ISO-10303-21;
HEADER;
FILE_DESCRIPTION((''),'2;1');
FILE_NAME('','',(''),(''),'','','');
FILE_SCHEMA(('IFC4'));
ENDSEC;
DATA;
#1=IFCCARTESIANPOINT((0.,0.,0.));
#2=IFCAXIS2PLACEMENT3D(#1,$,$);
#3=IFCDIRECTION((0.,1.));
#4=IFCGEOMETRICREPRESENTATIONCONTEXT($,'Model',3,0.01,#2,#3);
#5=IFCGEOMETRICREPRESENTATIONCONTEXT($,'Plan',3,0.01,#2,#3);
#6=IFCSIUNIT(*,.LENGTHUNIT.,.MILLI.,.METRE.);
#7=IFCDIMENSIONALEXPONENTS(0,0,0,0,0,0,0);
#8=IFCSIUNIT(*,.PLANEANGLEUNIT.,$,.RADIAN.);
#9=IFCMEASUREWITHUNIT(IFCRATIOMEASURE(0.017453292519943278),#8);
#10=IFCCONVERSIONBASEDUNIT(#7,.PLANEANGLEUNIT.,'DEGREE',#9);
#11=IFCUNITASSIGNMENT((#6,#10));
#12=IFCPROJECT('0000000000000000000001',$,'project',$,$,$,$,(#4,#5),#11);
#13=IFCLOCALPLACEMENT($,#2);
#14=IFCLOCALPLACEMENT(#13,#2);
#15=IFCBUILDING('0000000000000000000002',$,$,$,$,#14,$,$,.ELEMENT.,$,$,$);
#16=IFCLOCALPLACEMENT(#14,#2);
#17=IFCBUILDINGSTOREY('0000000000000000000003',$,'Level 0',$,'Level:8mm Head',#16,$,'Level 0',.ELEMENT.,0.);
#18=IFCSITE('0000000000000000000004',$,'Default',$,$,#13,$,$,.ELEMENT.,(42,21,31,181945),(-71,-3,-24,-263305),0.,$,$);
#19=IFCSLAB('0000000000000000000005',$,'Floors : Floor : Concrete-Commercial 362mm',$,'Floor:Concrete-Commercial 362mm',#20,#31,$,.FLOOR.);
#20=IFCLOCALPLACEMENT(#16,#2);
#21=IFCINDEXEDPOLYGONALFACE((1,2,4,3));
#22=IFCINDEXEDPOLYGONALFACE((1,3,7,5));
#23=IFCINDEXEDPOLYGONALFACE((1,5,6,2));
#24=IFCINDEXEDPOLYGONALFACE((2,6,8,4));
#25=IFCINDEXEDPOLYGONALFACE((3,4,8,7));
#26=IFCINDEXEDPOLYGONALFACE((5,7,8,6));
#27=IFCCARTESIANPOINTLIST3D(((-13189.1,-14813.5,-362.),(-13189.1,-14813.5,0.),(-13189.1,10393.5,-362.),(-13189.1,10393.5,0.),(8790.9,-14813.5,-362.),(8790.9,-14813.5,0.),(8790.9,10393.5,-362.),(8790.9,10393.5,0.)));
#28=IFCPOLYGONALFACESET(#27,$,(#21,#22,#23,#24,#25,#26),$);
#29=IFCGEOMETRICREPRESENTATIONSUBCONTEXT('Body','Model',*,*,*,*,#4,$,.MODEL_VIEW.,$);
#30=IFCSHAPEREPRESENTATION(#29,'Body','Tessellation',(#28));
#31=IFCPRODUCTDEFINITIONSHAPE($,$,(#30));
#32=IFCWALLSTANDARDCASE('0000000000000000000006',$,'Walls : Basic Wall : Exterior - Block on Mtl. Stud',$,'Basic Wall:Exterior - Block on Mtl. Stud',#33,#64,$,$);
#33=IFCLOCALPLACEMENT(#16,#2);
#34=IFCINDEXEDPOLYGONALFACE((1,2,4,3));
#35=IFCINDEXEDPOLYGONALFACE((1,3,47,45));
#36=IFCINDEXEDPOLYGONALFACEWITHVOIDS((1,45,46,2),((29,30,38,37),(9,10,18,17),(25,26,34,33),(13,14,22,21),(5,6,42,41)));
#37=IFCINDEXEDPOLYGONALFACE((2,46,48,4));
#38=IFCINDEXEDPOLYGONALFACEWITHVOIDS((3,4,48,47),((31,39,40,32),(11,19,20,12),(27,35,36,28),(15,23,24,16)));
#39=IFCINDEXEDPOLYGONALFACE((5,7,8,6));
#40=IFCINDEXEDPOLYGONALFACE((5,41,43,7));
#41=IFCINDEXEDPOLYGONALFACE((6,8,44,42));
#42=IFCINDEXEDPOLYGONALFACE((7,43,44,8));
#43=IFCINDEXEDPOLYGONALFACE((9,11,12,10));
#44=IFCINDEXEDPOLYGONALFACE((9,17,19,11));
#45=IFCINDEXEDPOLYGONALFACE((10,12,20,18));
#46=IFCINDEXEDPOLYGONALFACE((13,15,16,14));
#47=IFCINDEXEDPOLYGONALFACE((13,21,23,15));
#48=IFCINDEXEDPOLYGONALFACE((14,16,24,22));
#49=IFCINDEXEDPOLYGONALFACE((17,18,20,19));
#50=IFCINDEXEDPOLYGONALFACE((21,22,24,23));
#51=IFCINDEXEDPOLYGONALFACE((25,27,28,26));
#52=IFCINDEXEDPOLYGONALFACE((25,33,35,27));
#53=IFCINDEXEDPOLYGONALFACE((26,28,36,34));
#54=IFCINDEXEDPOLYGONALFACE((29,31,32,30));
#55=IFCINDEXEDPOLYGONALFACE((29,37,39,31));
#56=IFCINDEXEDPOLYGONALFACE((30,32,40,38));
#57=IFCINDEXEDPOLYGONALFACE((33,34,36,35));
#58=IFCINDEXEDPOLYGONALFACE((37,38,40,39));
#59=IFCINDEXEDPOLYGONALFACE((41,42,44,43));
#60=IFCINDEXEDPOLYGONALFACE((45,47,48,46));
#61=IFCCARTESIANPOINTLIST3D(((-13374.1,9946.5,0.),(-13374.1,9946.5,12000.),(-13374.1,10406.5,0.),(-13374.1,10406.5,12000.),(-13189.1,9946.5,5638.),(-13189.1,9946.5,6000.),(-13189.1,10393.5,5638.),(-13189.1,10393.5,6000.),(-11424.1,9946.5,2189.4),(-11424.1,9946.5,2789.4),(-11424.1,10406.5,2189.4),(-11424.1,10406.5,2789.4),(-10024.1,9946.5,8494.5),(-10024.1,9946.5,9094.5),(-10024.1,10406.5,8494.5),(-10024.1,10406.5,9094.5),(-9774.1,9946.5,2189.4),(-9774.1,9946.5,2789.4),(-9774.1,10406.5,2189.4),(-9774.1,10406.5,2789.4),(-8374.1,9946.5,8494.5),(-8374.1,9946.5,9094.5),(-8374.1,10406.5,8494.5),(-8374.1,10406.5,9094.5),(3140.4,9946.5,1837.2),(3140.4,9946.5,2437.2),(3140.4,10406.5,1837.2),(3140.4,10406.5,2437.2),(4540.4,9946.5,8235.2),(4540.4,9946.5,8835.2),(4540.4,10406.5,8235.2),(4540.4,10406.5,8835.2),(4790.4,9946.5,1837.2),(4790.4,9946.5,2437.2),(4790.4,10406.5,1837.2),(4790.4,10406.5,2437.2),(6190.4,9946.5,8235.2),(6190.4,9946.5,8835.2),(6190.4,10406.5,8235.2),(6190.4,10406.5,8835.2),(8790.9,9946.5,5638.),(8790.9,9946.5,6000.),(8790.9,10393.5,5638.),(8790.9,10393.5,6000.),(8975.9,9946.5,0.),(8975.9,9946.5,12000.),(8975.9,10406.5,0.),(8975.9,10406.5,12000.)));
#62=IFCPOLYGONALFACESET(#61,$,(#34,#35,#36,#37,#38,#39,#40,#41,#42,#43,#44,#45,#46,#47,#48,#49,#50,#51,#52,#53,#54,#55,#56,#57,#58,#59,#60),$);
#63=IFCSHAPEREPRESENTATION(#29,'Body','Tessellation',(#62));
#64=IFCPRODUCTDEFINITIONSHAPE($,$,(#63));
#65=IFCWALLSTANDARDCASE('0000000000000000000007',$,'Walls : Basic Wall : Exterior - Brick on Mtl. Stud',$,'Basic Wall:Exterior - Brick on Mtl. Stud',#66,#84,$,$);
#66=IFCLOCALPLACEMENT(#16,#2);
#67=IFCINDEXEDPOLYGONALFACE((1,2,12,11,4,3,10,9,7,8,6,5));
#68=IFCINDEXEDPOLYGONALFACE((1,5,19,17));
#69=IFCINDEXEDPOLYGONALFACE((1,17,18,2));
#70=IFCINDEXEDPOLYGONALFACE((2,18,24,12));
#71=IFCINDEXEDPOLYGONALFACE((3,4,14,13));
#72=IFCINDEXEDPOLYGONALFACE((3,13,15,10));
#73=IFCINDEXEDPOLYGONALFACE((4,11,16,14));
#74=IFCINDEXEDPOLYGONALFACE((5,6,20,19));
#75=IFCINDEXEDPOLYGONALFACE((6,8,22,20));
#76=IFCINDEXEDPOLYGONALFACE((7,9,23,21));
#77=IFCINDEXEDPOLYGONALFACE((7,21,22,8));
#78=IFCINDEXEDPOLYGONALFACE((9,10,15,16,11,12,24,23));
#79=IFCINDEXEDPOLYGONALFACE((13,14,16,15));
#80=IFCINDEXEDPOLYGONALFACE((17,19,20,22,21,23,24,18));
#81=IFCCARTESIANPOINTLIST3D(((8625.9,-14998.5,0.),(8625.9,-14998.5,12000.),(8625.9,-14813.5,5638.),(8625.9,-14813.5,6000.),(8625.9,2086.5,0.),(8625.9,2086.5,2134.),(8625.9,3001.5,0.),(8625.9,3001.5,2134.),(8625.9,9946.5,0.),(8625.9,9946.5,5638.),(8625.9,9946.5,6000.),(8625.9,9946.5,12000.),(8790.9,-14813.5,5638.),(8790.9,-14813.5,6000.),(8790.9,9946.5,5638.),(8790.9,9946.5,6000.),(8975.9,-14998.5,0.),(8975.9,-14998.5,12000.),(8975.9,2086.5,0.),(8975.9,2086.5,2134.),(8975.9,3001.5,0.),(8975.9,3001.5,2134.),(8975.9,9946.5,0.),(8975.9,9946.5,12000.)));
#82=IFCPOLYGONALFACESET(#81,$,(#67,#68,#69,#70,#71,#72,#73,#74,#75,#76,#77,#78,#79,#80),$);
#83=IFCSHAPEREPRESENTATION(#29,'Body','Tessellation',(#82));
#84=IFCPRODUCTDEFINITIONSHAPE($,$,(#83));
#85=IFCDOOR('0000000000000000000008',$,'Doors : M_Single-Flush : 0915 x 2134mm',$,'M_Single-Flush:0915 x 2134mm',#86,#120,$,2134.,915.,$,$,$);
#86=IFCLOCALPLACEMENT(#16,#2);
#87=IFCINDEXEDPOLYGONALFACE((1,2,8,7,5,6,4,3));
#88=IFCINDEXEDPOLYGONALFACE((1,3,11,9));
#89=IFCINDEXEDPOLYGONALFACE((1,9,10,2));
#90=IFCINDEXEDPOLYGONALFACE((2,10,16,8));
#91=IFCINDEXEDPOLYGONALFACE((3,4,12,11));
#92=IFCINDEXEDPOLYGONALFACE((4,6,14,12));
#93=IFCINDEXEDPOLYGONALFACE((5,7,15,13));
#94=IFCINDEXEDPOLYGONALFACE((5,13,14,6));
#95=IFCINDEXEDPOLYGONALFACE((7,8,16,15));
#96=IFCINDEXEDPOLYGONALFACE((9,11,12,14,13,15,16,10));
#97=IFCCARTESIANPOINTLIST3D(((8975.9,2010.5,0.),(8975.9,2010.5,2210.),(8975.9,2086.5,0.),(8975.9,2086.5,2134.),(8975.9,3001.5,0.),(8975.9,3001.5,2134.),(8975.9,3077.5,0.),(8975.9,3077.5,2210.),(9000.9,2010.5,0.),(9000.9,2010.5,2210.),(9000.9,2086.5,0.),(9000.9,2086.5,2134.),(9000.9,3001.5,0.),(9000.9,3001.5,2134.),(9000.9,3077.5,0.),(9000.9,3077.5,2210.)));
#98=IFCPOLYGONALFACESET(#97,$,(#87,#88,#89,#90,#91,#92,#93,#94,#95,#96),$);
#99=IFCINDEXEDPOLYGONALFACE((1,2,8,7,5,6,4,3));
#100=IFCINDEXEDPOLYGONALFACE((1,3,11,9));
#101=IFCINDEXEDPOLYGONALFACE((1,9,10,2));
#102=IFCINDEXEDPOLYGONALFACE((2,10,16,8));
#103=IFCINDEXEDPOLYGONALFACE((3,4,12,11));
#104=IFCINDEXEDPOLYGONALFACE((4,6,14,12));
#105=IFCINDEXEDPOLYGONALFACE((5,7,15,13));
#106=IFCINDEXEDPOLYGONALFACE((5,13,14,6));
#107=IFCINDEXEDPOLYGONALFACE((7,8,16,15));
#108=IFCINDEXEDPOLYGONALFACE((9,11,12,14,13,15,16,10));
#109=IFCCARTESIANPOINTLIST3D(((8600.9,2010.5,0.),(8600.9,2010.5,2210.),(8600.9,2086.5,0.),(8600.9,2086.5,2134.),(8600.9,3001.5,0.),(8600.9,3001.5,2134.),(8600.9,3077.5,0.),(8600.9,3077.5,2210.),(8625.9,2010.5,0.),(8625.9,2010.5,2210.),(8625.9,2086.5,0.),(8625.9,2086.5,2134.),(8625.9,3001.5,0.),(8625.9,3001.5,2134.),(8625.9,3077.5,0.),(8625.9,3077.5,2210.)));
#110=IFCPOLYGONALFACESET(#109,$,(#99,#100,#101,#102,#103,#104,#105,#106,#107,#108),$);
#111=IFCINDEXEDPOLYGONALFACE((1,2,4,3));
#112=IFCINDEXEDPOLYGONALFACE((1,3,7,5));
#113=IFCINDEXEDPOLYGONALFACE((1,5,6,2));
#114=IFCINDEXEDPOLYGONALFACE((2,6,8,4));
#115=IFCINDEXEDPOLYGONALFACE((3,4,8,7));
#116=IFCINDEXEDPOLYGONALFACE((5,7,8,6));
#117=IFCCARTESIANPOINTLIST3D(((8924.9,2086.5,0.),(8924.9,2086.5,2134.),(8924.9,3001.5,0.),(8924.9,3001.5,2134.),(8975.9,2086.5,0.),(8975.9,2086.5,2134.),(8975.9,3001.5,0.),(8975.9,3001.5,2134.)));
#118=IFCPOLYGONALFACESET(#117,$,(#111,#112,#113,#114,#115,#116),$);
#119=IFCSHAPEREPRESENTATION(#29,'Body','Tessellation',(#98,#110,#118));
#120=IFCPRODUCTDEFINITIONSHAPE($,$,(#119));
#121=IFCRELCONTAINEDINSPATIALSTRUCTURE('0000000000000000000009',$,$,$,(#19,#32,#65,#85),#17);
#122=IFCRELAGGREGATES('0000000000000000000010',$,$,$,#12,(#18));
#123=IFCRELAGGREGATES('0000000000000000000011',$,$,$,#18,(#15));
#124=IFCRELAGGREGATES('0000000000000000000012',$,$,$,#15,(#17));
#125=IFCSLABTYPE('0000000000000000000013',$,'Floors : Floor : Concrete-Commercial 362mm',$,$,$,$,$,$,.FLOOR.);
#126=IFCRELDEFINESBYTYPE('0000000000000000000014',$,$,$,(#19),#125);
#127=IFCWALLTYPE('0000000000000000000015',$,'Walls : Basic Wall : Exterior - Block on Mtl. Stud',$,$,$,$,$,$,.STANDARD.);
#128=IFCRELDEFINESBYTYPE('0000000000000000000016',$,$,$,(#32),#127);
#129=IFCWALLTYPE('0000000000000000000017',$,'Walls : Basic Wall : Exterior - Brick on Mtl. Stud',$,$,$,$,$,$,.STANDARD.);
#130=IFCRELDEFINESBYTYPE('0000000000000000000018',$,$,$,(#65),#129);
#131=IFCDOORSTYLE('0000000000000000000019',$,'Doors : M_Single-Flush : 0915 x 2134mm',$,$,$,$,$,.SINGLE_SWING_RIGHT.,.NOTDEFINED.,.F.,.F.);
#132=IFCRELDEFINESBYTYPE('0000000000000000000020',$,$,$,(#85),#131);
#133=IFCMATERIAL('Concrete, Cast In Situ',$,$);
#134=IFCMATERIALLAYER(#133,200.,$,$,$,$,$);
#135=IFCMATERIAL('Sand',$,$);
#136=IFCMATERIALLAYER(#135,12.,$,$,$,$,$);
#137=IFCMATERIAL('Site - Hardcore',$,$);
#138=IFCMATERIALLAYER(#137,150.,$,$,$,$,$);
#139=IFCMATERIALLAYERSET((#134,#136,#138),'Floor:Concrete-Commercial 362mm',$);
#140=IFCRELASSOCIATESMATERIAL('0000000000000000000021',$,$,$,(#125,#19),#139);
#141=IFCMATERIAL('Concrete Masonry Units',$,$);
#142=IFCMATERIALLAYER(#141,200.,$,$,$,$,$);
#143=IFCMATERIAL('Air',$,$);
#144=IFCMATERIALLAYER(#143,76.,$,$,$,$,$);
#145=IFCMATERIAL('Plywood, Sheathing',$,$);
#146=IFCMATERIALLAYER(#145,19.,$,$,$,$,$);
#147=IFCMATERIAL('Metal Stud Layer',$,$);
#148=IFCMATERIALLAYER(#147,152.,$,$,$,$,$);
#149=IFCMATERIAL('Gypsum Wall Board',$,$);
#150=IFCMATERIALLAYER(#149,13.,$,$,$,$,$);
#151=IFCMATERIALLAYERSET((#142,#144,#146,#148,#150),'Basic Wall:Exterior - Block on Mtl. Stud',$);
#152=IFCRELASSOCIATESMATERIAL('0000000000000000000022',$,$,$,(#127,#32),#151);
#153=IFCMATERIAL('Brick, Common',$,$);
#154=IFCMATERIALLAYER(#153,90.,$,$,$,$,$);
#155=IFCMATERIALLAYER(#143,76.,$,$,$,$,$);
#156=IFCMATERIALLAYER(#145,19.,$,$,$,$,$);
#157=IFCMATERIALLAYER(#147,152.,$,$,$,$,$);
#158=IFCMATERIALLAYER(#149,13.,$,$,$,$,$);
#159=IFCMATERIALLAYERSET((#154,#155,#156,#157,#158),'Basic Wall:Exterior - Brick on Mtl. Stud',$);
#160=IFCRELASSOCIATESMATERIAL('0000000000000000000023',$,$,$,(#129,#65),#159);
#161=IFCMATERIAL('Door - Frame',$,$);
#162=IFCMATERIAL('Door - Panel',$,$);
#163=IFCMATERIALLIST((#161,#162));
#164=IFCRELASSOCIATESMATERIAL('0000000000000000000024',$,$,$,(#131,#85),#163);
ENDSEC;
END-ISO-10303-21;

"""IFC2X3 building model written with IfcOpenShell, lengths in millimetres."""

from ifc_helpers import new_model, entity, si_unit, converted_unit, direction, frame, frame_2d, origin, place, context, subcontext, project, spatial, polyline, rectangle, outline, extrude, source, transform, mapped, material, material_list, layer, layer_set, layer_usage, type_object, type_shapes, element, fill, save


model = new_model("IFC2X3")

# Units and contexts
model_context = context("Model", 3, precision=0.01, world=origin(), true_north=direction((0.0, 1.0)))
plan_context = context("Plan", 3, precision=0.01, world=origin(), true_north=direction((0.0, 1.0)))
body_context = subcontext(model_context, "Body", "Model", "MODEL_VIEW")
ifc_project = project(units=[si_unit("LENGTHUNIT", "METRE", prefix="MILLI"), converted_unit("PLANEANGLEUNIT", "DEGREE", entity("IfcRatioMeasure", 0.017453292519943278), si_unit("PLANEANGLEUNIT", "RADIAN"), dimensions=[0, 0, 0, 0, 0, 0, 0])], contexts=[model_context, plan_context])

# Site, building, storey
site_placement = place(None, origin())
site = spatial("IfcSite", under=ifc_project, at=site_placement, Name="Default", CompositionType="ELEMENT", RefLatitude=(42, 21, 31, 181945), RefLongitude=(-71, -3, -24, -263305), RefElevation=0.0)
building_placement = place(site_placement, origin())
building = spatial("IfcBuilding", under=site, at=building_placement, CompositionType="ELEMENT")
storey_placement = place(building_placement, origin())
storey = spatial("IfcBuildingStorey", under=building, at=storey_placement, Name="Level 0", ObjectType="Level:8mm Head", LongName="Level 0", CompositionType="ELEMENT", Elevation=0.0)

# Slab
ifc_material_1 = material(Name="Concrete, Cast In Situ")
ifc_layer_1 = layer(ifc_material_1, 200.0)
ifc_material_2 = material(Name="Sand")
ifc_layer_2 = layer(ifc_material_2, 12.0)
ifc_material_3 = material(Name="Site - Hardcore")
ifc_layer_3 = layer(ifc_material_3, 150.0)
ifc_layer_set_1 = layer_set([ifc_layer_1, ifc_layer_2, ifc_layer_3], Name="Floor:Concrete-Commercial 362mm")
ifc_layer_usage_1 = layer_usage(ifc_layer_set_1, "AXIS3", "POSITIVE", 0.0)
slab_type = type_object("IfcSlabType", Name="Floors : Floor : Concrete-Commercial 362mm", PredefinedType="FLOOR", material=ifc_layer_set_1)
slab_placement = place(storey_placement, origin())
element("IfcSlab", 1, at=slab_placement, inside=storey, type_object=slab_type, material=ifc_layer_usage_1, Name="Floors : Floor : Concrete-Commercial 362mm", ObjectType="Floor:Concrete-Commercial 362mm", PredefinedType="FLOOR", context=body_context, shape_type="SweptSolid", body=[
    extrude(rectangle(XDim=25207.0, YDim=21980.0, at=frame_2d((0.0, 0.0), x_axis=(1.0, 0.0))), frame((-2199.1, -2210.0, 0.0), z_axis=(0.0, 0.0, -1.0), x_axis=(0.0, 1.0, 0.0)), (0.0, 0.0, 1.0), 362.0),
])

# Wall, openings
ifc_material_4 = material(Name="Concrete Masonry Units")
ifc_layer_4 = layer(ifc_material_4, 200.0)
ifc_material_5 = material(Name="Air")
ifc_layer_5 = layer(ifc_material_5, 76.0)
ifc_material_6 = material(Name="Plywood, Sheathing")
ifc_layer_6 = layer(ifc_material_6, 19.0)
ifc_material_7 = material(Name="Metal Stud Layer")
ifc_layer_7 = layer(ifc_material_7, 152.0)
ifc_material_8 = material(Name="Gypsum Wall Board")
ifc_layer_8 = layer(ifc_material_8, 13.0)
ifc_layer_set_2 = layer_set([ifc_layer_4, ifc_layer_5, ifc_layer_6, ifc_layer_7, ifc_layer_8], Name="Basic Wall:Exterior - Block on Mtl. Stud")
ifc_layer_usage_2 = layer_usage(ifc_layer_set_2, "AXIS2", "POSITIVE", -230.0)
wall_type_1 = type_object("IfcWallType", Name="Walls : Basic Wall : Exterior - Block on Mtl. Stud", PredefinedType="STANDARD", material=ifc_layer_set_2)
wall_1_placement = place(storey_placement, frame((-13374.1, 10176.5, 0.0)))
wall_1 = element("IfcWallStandardCase", 2, at=wall_1_placement, inside=storey, type_object=wall_type_1, material=ifc_layer_usage_2, Name="Walls : Basic Wall : Exterior - Block on Mtl. Stud", ObjectType="Basic Wall:Exterior - Block on Mtl. Stud", context=body_context, shape_type="SweptSolid", body=[
    extrude(rectangle(XDim=22350.0, YDim=460.0, at=frame_2d((11175.0, 0.0), x_axis=(-1.0, 0.0))), origin(), (0.0, 0.0, 1.0), 12000.0),
])
opening_1_placement = place(storey_placement, frame((-13374.1, 10176.5, 0.0)))
element("IfcOpeningElement", 3, at=opening_1_placement, cuts=wall_1, ObjectType="Opening", context=body_context, shape_type="SweptSolid", body=[
    extrude(rectangle(XDim=21980.0, YDim=447.0, at=frame_2d((0.0, -74.5), x_axis=(1.0, 0.0))), frame((11175.0, -81.0, 5638.0), z_axis=(0.0, 0.0, 1.0), x_axis=(-1.0, 0.0, 0.0)), (0.0, 0.0, 1.0), 362.0),
])
opening_2_placement = place(wall_1_placement, frame((16514.5, -230.0, 1837.2)))
element("IfcOpeningElement", 4, at=opening_2_placement, cuts=wall_1, ObjectType="Opening", context=body_context, shape_type="SweptSolid", body=[
    extrude(rectangle(XDim=600.0, YDim=1650.0, at=frame_2d((300.0, 825.0), x_axis=(-1.0, 0.0))), frame((0.0, 0.0, 0.0), z_axis=(0.0, 1.0, 0.0), x_axis=(0.0, 0.0, 1.0)), (0.0, 0.0, 1.0), 460.0),
])
opening_3_placement = place(wall_1_placement, frame((1950.0, -230.0, 2189.4)))
element("IfcOpeningElement", 5, at=opening_3_placement, cuts=wall_1, ObjectType="Opening", context=body_context, shape_type="SweptSolid", body=[
    extrude(rectangle(XDim=600.0, YDim=1650.0, at=frame_2d((300.0, 825.0), x_axis=(-1.0, 0.0))), frame((0.0, 0.0, 0.0), z_axis=(0.0, 1.0, 0.0), x_axis=(0.0, 0.0, 1.0)), (0.0, 0.0, 1.0), 460.0),
])
opening_4_placement = place(wall_1_placement, frame((17914.5, -230.0, 8235.2)))
element("IfcOpeningElement", 6, at=opening_4_placement, cuts=wall_1, ObjectType="Opening", context=body_context, shape_type="SweptSolid", body=[
    extrude(rectangle(XDim=600.0, YDim=1650.0, at=frame_2d((300.0, 825.0), x_axis=(-1.0, 0.0))), frame((0.0, 0.0, 0.0), z_axis=(0.0, 1.0, 0.0), x_axis=(0.0, 0.0, 1.0)), (0.0, 0.0, 1.0), 460.0),
])
opening_5_placement = place(wall_1_placement, frame((3350.0, -230.0, 8494.5)))
element("IfcOpeningElement", 7, at=opening_5_placement, cuts=wall_1, ObjectType="Opening", context=body_context, shape_type="SweptSolid", body=[
    extrude(rectangle(XDim=600.0, YDim=1650.0, at=frame_2d((300.0, 825.0), x_axis=(-1.0, 0.0))), frame((0.0, 0.0, 0.0), z_axis=(0.0, 1.0, 0.0), x_axis=(0.0, 0.0, 1.0)), (0.0, 0.0, 1.0), 460.0),
])

# Wall, openings, door
ifc_material_9 = material(Name="Brick, Common")
ifc_layer_9 = layer(ifc_material_9, 90.0)
ifc_layer_10 = layer(ifc_material_5, 76.0)
ifc_layer_11 = layer(ifc_material_6, 19.0)
ifc_layer_12 = layer(ifc_material_7, 152.0)
ifc_layer_13 = layer(ifc_material_8, 13.0)
ifc_layer_set_3 = layer_set([ifc_layer_9, ifc_layer_10, ifc_layer_11, ifc_layer_12, ifc_layer_13], Name="Basic Wall:Exterior - Brick on Mtl. Stud")
ifc_layer_usage_3 = layer_usage(ifc_layer_set_3, "AXIS2", "NEGATIVE", 175.0)
wall_type_2 = type_object("IfcWallType", Name="Walls : Basic Wall : Exterior - Brick on Mtl. Stud", PredefinedType="STANDARD", material=ifc_layer_set_3)
wall_2_placement = place(storey_placement, frame((8800.9, 9946.5, 0.0), z_axis=(0.0, 0.0, 1.0), x_axis=(0.0, -1.0, 0.0)))
wall_2 = element("IfcWallStandardCase", 8, at=wall_2_placement, inside=storey, type_object=wall_type_2, material=ifc_layer_usage_3, Name="Walls : Basic Wall : Exterior - Brick on Mtl. Stud", ObjectType="Basic Wall:Exterior - Brick on Mtl. Stud", context=body_context, shape_type="SweptSolid", body=[
    extrude(rectangle(XDim=24945.0, YDim=350.0, at=frame_2d((12472.5, 0.0), x_axis=(-1.0, 0.0))), origin(), (0.0, 0.0, 1.0), 12000.0),
])
opening_6_placement = place(storey_placement, frame((8800.9, 9946.5, 0.0), z_axis=(0.0, 0.0, 1.0), x_axis=(0.0, -1.0, 0.0)))
element("IfcOpeningElement", 9, at=opening_6_placement, cuts=wall_2, ObjectType="Opening", context=body_context, shape_type="SweptSolid", body=[
    extrude(rectangle(XDim=165.0, YDim=24760.0, at=frame_2d((16.5, 2443.0), x_axis=(1.0, 0.0))), frame((14823.0, -109.0, 5638.0), z_axis=(0.0, 0.0, 1.0), x_axis=(0.0, 1.0, 0.0)), (0.0, 0.0, 1.0), 362.0),
])
opening_7_placement = place(wall_2_placement, frame((6945.0, -175.0, 0.0)))
opening_7 = element("IfcOpeningElement", 10, at=opening_7_placement, cuts=wall_2, ObjectType="Opening", context=body_context, shape_type="SweptSolid", body=[
    extrude(rectangle(XDim=915.0, YDim=2134.0, at=frame_2d((1067.0, 457.5), x_axis=(0.0, 1.0))), frame((0.0, 0.0, 0.0), z_axis=(0.0, 1.0, 0.0), x_axis=(0.0, 0.0, 1.0)), (0.0, 0.0, 1.0), 350.0),
])
ifc_material_10 = material(Name="Door - Frame")
ifc_material_11 = material(Name="Door - Panel")
ifc_material_list = material_list([ifc_material_10, ifc_material_11])
door_style_1 = type_object("IfcDoorStyle", Name="Doors : M_Single-Flush : 0915 x 2134mm", ConstructionType="NOTDEFINED", OperationType="SINGLE_SWING_RIGHT", ParameterTakesPrecedence=False, Sizeable=False, material=ifc_material_list)
shared_shape_1 = source(origin(), body_context, "Body", "SweptSolid", [
    extrude(outline(polyline([(-533.5, -1124.0), (533.5, -1124.0), (533.5, 1086.0), (457.5, 1086.0), (457.5, -1048.0), (-457.5, -1048.0), (-457.5, 1086.0), (-533.5, 1086.0), (-533.5, -1124.0)])), frame((457.5, 350.0, 1086.0), z_axis=(0.0, 1.0, 0.0), x_axis=(1.0, 0.0, 0.0)), (0.0, 0.0, 1.0), 25.0),
    extrude(outline(polyline([(-1124.0, -533.5), (1086.0, -533.5), (1086.0, -457.5), (-1048.0, -457.5), (-1048.0, 457.5), (1086.0, 457.5), (1086.0, 533.5), (-1124.0, 533.5), (-1124.0, -533.5)])), frame((457.5, -25.0, 1086.0), z_axis=(0.0, 1.0, 0.0), x_axis=(0.0, 0.0, -1.0)), (0.0, 0.0, 1.0), 25.0),
    extrude(rectangle(XDim=51.0, YDim=915.0, at=frame_2d((0.0, 0.0), x_axis=(1.0, 0.0))), frame((457.5, 324.5, 0.0), z_axis=(0.0, 0.0, 1.0), x_axis=(0.0, 1.0, 0.0)), (0.0, 0.0, 1.0), 2134.0),
])
type_shapes(door_style_1, [shared_shape_1])
door_1_placement = place(opening_7_placement, origin())
door_1 = element("IfcDoor", 11, at=door_1_placement, inside=storey, type_object=door_style_1, material=ifc_material_list, Name="Doors : M_Single-Flush : 0915 x 2134mm", ObjectType="M_Single-Flush:0915 x 2134mm", OverallHeight=2134.0, OverallWidth=915.0, context=body_context, shape_type="MappedRepresentation", body=[
    mapped(shared_shape_1, transform((0.0, 0.0, 0.0), scale=1.0)),
])
fill(opening_7, door_1)

save(model, "model.ifc")
